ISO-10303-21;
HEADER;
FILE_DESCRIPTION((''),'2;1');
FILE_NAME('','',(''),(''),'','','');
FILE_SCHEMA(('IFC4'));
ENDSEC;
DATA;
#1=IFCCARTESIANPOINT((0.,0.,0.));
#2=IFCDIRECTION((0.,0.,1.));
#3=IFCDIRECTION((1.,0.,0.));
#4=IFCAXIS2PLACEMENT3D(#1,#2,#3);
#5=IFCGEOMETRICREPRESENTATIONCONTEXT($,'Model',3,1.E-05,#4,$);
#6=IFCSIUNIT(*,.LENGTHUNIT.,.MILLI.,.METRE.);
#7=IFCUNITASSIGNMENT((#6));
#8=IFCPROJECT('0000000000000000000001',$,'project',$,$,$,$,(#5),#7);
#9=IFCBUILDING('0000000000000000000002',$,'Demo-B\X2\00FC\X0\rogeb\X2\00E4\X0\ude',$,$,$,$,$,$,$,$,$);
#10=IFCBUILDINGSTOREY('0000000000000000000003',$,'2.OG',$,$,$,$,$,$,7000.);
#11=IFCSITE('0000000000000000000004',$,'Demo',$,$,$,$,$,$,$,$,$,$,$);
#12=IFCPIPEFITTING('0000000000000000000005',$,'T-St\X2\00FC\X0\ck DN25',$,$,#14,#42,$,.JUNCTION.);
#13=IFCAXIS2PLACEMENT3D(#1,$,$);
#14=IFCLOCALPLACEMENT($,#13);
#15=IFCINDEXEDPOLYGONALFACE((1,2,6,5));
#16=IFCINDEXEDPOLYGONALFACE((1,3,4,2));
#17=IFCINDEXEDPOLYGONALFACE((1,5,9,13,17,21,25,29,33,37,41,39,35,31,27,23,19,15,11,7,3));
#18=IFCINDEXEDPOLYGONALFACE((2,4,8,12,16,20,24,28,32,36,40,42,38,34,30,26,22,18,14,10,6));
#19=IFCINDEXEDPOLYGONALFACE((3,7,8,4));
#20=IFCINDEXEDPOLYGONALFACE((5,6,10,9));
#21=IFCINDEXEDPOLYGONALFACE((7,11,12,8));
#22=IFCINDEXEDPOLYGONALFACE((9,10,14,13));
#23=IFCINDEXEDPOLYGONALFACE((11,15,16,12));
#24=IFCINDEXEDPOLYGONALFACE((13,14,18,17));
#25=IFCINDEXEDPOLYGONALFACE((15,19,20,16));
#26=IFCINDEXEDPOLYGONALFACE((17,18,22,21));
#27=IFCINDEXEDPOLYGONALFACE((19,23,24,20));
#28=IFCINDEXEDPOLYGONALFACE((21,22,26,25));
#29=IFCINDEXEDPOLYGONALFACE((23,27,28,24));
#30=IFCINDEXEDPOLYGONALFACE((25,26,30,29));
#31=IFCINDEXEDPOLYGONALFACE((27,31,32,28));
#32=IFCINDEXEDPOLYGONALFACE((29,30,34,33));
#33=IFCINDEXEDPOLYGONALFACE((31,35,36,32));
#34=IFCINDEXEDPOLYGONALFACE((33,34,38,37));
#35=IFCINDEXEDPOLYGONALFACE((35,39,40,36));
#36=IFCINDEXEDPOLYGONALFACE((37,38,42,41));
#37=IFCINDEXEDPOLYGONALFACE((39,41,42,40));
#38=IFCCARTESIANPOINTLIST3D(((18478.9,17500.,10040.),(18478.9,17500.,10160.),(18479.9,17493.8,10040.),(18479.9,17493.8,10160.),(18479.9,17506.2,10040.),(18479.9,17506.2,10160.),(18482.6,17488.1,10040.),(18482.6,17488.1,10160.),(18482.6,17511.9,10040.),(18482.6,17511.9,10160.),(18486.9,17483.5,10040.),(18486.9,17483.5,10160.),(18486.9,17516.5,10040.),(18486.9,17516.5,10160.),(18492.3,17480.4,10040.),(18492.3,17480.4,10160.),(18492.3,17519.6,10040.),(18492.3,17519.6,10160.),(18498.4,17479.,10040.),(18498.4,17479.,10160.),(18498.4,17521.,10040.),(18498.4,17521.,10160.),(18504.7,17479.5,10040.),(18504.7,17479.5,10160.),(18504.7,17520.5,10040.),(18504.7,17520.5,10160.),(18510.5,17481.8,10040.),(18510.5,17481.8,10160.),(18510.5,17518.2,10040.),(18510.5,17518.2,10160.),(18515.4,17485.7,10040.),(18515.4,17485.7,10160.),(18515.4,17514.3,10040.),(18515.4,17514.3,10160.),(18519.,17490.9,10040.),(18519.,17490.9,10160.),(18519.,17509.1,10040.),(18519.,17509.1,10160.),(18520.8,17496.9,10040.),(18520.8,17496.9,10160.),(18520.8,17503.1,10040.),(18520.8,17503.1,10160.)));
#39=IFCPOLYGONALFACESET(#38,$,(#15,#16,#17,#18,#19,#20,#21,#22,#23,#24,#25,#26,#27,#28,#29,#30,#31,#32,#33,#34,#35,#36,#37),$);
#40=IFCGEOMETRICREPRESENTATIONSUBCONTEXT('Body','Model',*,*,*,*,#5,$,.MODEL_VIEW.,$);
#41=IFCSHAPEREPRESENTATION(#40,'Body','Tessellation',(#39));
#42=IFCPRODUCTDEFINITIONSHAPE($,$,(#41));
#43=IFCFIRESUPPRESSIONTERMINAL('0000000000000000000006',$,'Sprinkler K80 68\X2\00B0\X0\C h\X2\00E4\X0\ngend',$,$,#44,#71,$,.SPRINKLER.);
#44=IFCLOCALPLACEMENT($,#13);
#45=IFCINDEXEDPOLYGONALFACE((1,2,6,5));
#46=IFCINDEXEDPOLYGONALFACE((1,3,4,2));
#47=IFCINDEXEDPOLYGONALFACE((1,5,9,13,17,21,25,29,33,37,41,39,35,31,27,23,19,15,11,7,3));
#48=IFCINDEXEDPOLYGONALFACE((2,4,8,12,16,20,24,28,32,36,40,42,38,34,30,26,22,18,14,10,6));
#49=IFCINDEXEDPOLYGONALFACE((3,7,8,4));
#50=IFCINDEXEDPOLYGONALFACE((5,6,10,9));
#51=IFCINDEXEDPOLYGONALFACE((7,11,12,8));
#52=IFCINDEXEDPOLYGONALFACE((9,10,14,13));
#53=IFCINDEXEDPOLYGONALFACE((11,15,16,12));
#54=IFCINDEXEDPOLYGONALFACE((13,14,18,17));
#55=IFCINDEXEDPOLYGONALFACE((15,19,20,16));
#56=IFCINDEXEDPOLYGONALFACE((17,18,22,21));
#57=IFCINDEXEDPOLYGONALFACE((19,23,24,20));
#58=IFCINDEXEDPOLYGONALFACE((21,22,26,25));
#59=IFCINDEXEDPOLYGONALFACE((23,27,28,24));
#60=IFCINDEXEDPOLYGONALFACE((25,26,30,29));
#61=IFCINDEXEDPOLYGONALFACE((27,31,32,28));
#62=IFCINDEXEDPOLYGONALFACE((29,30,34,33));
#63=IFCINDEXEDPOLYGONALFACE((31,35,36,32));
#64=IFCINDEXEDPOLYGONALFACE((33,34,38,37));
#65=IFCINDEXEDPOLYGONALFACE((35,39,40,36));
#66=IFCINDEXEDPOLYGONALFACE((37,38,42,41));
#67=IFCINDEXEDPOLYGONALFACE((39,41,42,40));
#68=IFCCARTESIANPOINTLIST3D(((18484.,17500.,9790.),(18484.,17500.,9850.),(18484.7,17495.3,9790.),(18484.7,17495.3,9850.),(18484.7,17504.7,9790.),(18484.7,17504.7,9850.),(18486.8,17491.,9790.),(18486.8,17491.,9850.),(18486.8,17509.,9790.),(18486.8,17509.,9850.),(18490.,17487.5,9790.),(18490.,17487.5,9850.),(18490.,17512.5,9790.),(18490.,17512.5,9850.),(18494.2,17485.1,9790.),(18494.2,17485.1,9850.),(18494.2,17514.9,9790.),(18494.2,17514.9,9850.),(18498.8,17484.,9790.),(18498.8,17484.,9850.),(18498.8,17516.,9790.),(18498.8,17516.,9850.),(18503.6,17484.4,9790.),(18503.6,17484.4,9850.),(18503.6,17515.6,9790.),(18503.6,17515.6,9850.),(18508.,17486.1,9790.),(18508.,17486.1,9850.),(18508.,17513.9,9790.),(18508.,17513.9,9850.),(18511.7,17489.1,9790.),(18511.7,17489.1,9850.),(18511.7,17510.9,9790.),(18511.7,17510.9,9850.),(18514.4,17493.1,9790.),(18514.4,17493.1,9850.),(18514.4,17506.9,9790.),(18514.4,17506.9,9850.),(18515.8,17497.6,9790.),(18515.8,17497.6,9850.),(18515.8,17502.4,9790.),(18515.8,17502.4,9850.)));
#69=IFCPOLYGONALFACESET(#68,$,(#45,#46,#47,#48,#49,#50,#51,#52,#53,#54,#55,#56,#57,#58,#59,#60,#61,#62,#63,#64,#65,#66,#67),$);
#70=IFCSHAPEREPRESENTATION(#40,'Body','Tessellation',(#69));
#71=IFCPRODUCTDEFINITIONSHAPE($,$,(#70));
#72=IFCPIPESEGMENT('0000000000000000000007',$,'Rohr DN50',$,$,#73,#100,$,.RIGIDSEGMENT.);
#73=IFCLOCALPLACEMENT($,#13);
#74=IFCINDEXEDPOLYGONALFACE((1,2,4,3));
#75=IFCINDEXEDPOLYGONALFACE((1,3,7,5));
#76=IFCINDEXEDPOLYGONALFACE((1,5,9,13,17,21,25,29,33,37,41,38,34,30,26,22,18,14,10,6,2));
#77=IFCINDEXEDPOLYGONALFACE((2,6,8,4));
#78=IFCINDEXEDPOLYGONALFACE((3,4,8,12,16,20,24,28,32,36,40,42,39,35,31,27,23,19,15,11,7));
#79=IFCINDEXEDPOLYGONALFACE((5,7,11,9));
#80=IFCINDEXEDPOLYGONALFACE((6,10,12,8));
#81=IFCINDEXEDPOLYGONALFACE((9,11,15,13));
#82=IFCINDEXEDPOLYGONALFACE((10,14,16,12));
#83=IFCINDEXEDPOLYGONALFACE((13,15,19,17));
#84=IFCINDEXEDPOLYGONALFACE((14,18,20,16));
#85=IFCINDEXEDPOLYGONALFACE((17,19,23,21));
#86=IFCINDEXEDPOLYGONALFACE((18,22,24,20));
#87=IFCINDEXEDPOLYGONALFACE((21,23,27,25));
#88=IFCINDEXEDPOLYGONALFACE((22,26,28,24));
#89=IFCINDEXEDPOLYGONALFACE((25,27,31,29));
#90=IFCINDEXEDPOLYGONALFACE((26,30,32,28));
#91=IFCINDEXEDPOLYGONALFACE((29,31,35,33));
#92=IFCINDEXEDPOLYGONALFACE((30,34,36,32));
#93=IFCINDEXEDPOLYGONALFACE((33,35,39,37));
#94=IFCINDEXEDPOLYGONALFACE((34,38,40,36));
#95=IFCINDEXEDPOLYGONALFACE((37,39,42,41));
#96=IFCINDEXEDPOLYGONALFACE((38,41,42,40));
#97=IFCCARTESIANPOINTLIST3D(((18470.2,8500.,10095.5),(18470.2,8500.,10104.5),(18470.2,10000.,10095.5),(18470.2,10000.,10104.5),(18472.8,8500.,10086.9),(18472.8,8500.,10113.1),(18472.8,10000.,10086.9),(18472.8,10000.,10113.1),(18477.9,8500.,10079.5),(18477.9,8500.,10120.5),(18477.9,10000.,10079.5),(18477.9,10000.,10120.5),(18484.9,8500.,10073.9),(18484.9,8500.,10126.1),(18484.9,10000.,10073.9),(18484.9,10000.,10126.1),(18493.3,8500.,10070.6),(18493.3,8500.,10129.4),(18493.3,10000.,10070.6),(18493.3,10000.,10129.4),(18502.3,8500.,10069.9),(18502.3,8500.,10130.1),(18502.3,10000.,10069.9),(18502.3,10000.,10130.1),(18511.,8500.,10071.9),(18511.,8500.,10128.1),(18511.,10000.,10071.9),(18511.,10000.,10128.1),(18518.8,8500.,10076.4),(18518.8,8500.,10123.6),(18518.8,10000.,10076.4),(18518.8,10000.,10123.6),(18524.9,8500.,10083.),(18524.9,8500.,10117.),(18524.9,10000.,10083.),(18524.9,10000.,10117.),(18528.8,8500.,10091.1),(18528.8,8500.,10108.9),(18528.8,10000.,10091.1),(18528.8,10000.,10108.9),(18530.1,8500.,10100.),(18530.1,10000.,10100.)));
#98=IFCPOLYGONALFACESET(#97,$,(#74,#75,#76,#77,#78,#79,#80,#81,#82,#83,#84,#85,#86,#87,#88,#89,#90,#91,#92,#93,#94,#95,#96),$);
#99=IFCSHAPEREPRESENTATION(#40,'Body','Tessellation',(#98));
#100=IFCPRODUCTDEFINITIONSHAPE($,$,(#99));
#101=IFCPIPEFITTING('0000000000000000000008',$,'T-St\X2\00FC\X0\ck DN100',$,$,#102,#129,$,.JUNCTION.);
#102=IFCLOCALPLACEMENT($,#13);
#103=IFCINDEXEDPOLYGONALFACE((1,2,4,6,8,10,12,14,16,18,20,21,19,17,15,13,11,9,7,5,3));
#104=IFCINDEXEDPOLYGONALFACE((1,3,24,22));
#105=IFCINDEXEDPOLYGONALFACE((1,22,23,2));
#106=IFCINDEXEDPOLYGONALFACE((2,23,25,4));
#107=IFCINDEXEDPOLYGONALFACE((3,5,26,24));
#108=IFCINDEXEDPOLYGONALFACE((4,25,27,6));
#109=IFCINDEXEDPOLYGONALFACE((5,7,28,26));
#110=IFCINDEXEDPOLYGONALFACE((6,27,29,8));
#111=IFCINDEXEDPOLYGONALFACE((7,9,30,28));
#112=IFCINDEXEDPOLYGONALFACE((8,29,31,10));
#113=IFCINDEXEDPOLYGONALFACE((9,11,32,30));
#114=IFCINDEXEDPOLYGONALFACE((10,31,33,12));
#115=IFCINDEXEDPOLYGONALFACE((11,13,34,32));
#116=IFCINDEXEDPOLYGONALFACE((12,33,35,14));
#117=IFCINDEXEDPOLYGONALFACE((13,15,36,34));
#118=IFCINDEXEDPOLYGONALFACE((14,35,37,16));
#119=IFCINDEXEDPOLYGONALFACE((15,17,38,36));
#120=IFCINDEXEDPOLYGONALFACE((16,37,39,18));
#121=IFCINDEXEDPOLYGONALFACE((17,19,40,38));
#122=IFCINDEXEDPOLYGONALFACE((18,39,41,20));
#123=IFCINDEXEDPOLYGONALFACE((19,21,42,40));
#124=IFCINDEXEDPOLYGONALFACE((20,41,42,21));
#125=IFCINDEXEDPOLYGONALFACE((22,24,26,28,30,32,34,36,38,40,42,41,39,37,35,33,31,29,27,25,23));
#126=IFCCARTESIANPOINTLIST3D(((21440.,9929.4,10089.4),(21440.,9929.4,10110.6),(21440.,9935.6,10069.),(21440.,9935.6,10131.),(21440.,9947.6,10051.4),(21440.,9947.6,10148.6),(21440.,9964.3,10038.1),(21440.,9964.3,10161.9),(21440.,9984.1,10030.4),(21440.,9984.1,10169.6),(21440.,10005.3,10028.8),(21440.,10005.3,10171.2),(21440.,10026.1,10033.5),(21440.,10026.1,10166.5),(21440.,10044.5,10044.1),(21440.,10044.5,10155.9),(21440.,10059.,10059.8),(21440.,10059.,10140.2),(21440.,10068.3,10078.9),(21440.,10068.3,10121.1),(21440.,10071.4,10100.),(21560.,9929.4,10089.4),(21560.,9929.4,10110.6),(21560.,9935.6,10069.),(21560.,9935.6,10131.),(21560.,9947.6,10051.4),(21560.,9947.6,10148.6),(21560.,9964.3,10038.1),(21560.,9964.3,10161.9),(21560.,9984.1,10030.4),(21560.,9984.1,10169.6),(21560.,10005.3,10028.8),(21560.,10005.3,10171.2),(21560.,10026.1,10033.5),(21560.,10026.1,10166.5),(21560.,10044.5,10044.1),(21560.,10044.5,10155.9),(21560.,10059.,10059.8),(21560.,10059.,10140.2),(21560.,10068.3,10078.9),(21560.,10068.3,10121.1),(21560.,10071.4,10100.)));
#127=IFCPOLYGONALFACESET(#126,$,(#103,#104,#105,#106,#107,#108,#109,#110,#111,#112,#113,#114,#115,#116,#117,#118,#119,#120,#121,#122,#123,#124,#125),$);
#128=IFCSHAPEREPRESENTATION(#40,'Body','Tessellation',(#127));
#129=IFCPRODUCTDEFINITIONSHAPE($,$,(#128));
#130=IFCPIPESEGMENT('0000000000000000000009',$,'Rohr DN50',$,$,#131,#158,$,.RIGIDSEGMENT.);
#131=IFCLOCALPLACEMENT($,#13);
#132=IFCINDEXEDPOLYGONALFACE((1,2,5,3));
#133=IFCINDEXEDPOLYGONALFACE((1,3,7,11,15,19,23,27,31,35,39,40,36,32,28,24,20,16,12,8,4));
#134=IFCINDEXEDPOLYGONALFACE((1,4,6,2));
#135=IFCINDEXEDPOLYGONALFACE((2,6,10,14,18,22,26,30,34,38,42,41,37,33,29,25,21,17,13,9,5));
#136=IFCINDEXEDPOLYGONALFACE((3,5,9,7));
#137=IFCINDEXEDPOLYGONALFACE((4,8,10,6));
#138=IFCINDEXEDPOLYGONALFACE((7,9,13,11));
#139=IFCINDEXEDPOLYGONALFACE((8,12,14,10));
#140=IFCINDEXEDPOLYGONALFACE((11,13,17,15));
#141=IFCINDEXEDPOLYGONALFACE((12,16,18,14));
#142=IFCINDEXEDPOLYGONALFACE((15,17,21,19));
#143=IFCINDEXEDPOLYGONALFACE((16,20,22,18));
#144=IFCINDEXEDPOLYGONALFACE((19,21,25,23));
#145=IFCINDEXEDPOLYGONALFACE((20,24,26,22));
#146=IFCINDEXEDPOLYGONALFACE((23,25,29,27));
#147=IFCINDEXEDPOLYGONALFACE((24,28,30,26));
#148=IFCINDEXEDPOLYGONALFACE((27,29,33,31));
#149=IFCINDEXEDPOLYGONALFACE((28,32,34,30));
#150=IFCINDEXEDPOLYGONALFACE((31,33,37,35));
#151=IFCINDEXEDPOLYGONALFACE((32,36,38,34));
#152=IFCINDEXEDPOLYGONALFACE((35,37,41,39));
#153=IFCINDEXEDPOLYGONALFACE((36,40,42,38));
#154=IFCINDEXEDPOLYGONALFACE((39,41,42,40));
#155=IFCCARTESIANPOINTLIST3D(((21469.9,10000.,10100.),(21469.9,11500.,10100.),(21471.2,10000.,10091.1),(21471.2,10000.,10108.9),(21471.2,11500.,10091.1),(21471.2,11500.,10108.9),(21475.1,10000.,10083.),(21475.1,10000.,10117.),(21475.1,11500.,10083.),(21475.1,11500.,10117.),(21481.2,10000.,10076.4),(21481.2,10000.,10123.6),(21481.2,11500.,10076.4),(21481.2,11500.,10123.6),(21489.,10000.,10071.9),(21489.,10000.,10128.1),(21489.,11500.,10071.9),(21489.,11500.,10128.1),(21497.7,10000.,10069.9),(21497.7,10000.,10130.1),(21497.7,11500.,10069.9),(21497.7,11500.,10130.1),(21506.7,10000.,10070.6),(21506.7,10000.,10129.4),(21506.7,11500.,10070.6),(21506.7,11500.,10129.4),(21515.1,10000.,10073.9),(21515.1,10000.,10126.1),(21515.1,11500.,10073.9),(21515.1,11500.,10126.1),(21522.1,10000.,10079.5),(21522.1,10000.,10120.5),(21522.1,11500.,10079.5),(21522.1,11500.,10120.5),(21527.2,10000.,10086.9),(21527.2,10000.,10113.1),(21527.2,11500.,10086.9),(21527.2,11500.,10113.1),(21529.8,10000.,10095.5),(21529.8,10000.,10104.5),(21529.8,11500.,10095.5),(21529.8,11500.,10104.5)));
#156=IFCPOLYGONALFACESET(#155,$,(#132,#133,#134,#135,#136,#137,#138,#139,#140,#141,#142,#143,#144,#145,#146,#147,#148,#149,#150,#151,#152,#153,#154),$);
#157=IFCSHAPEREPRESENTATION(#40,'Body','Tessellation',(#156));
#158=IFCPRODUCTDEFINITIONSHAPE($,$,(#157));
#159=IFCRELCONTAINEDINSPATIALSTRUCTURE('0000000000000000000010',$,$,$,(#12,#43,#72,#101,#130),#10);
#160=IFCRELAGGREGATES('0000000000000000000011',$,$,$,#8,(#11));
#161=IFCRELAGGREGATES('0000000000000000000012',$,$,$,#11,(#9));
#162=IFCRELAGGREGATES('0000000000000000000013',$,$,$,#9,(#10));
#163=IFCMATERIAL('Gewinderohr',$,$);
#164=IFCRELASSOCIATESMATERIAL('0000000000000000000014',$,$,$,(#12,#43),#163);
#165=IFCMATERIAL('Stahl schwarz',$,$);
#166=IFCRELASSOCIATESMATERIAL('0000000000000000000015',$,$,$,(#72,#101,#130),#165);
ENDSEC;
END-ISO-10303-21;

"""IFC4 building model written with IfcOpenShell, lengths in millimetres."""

from ifc_helpers import new_model, si_unit, frame, origin_with_axes, place, context, subcontext, project, spatial, circle, extrude, material, element, save


model = new_model("IFC4")

# Units and contexts
model_context = context("Model", 3, precision=1e-05, world=origin_with_axes())
body_context = subcontext(model_context, "Body", "Model", "MODEL_VIEW")
ifc_project = project(units=[si_unit("LENGTHUNIT", "METRE", prefix="MILLI")], contexts=[model_context])

# Site, building, storey
site = spatial("IfcSite", under=ifc_project, Name="Demo")
building = spatial("IfcBuilding", under=site, Name="Demo-Bürogebäude")
storey = spatial("IfcBuildingStorey", under=building, Name="2.OG", Elevation=7000.0)

# Shared definitions
ifc_material_1 = material(Name="Gewinderohr")

# Shared definitions
ifc_material_2 = material(Name="Stahl schwarz")

# Pipe fitting
pipe_fitting_1_placement = place(None, frame((18500.0, 17500.0, 10160.0), z_axis=(0.0, 0.0, -1.0), x_axis=(-1.0, 0.0, 0.0)))
element("IfcPipeFitting", 1, at=pipe_fitting_1_placement, inside=storey, material=ifc_material_1, Name="T-Stück DN25", PredefinedType="JUNCTION", context=body_context, shape_type="SweptSolid", body=[
    extrude(circle(Radius=21.1), origin_with_axes(), (0.0, 0.0, 1.0), 120.0),
])

# Fire suppression terminal
fire_suppression_terminal_1_placement = place(None, frame((18500.0, 17500.0, 9850.0), z_axis=(0.0, 0.0, -1.0), x_axis=(-1.0, 0.0, 0.0)))
element("IfcFireSuppressionTerminal", 2, at=fire_suppression_terminal_1_placement, inside=storey, material=ifc_material_1, Name="Sprinkler K80 68°C hängend", PredefinedType="SPRINKLER", context=body_context, shape_type="SweptSolid", body=[
    extrude(circle(Radius=16.0), origin_with_axes(), (0.0, 0.0, 1.0), 60.0),
])

# Pipe segment
pipe_segment_1_placement = place(None, frame((18500.0, 10000.0, 10100.0), z_axis=(0.0, -1.0, 0.0), x_axis=(1.0, 0.0, 0.0)))
element("IfcPipeSegment", 3, at=pipe_segment_1_placement, inside=storey, material=ifc_material_2, Name="Rohr DN50", PredefinedType="RIGIDSEGMENT", context=body_context, shape_type="SweptSolid", body=[
    extrude(circle(Radius=30.1), origin_with_axes(), (0.0, 0.0, 1.0), 1500.0),
])

# Pipe fitting
pipe_fitting_2_placement = place(None, frame((21440.0, 10000.0, 10100.0), z_axis=(1.0, 0.0, 0.0), x_axis=(0.0, 1.0, 0.0)))
element("IfcPipeFitting", 4, at=pipe_fitting_2_placement, inside=storey, material=ifc_material_2, Name="T-Stück DN100", PredefinedType="JUNCTION", context=body_context, shape_type="SweptSolid", body=[
    extrude(circle(Radius=71.4), origin_with_axes(), (0.0, 0.0, 1.0), 120.0),
])

# Pipe segment
pipe_segment_2_placement = place(None, frame((21500.0, 10000.0, 10100.0), z_axis=(0.0, 1.0, 0.0), x_axis=(-1.0, 0.0, 0.0)))
element("IfcPipeSegment", 5, at=pipe_segment_2_placement, inside=storey, material=ifc_material_2, Name="Rohr DN50", PredefinedType="RIGIDSEGMENT", context=body_context, shape_type="SweptSolid", body=[
    extrude(circle(Radius=30.1), origin_with_axes(), (0.0, 0.0, 1.0), 1500.0),
])

save(model, "model.ifc")
